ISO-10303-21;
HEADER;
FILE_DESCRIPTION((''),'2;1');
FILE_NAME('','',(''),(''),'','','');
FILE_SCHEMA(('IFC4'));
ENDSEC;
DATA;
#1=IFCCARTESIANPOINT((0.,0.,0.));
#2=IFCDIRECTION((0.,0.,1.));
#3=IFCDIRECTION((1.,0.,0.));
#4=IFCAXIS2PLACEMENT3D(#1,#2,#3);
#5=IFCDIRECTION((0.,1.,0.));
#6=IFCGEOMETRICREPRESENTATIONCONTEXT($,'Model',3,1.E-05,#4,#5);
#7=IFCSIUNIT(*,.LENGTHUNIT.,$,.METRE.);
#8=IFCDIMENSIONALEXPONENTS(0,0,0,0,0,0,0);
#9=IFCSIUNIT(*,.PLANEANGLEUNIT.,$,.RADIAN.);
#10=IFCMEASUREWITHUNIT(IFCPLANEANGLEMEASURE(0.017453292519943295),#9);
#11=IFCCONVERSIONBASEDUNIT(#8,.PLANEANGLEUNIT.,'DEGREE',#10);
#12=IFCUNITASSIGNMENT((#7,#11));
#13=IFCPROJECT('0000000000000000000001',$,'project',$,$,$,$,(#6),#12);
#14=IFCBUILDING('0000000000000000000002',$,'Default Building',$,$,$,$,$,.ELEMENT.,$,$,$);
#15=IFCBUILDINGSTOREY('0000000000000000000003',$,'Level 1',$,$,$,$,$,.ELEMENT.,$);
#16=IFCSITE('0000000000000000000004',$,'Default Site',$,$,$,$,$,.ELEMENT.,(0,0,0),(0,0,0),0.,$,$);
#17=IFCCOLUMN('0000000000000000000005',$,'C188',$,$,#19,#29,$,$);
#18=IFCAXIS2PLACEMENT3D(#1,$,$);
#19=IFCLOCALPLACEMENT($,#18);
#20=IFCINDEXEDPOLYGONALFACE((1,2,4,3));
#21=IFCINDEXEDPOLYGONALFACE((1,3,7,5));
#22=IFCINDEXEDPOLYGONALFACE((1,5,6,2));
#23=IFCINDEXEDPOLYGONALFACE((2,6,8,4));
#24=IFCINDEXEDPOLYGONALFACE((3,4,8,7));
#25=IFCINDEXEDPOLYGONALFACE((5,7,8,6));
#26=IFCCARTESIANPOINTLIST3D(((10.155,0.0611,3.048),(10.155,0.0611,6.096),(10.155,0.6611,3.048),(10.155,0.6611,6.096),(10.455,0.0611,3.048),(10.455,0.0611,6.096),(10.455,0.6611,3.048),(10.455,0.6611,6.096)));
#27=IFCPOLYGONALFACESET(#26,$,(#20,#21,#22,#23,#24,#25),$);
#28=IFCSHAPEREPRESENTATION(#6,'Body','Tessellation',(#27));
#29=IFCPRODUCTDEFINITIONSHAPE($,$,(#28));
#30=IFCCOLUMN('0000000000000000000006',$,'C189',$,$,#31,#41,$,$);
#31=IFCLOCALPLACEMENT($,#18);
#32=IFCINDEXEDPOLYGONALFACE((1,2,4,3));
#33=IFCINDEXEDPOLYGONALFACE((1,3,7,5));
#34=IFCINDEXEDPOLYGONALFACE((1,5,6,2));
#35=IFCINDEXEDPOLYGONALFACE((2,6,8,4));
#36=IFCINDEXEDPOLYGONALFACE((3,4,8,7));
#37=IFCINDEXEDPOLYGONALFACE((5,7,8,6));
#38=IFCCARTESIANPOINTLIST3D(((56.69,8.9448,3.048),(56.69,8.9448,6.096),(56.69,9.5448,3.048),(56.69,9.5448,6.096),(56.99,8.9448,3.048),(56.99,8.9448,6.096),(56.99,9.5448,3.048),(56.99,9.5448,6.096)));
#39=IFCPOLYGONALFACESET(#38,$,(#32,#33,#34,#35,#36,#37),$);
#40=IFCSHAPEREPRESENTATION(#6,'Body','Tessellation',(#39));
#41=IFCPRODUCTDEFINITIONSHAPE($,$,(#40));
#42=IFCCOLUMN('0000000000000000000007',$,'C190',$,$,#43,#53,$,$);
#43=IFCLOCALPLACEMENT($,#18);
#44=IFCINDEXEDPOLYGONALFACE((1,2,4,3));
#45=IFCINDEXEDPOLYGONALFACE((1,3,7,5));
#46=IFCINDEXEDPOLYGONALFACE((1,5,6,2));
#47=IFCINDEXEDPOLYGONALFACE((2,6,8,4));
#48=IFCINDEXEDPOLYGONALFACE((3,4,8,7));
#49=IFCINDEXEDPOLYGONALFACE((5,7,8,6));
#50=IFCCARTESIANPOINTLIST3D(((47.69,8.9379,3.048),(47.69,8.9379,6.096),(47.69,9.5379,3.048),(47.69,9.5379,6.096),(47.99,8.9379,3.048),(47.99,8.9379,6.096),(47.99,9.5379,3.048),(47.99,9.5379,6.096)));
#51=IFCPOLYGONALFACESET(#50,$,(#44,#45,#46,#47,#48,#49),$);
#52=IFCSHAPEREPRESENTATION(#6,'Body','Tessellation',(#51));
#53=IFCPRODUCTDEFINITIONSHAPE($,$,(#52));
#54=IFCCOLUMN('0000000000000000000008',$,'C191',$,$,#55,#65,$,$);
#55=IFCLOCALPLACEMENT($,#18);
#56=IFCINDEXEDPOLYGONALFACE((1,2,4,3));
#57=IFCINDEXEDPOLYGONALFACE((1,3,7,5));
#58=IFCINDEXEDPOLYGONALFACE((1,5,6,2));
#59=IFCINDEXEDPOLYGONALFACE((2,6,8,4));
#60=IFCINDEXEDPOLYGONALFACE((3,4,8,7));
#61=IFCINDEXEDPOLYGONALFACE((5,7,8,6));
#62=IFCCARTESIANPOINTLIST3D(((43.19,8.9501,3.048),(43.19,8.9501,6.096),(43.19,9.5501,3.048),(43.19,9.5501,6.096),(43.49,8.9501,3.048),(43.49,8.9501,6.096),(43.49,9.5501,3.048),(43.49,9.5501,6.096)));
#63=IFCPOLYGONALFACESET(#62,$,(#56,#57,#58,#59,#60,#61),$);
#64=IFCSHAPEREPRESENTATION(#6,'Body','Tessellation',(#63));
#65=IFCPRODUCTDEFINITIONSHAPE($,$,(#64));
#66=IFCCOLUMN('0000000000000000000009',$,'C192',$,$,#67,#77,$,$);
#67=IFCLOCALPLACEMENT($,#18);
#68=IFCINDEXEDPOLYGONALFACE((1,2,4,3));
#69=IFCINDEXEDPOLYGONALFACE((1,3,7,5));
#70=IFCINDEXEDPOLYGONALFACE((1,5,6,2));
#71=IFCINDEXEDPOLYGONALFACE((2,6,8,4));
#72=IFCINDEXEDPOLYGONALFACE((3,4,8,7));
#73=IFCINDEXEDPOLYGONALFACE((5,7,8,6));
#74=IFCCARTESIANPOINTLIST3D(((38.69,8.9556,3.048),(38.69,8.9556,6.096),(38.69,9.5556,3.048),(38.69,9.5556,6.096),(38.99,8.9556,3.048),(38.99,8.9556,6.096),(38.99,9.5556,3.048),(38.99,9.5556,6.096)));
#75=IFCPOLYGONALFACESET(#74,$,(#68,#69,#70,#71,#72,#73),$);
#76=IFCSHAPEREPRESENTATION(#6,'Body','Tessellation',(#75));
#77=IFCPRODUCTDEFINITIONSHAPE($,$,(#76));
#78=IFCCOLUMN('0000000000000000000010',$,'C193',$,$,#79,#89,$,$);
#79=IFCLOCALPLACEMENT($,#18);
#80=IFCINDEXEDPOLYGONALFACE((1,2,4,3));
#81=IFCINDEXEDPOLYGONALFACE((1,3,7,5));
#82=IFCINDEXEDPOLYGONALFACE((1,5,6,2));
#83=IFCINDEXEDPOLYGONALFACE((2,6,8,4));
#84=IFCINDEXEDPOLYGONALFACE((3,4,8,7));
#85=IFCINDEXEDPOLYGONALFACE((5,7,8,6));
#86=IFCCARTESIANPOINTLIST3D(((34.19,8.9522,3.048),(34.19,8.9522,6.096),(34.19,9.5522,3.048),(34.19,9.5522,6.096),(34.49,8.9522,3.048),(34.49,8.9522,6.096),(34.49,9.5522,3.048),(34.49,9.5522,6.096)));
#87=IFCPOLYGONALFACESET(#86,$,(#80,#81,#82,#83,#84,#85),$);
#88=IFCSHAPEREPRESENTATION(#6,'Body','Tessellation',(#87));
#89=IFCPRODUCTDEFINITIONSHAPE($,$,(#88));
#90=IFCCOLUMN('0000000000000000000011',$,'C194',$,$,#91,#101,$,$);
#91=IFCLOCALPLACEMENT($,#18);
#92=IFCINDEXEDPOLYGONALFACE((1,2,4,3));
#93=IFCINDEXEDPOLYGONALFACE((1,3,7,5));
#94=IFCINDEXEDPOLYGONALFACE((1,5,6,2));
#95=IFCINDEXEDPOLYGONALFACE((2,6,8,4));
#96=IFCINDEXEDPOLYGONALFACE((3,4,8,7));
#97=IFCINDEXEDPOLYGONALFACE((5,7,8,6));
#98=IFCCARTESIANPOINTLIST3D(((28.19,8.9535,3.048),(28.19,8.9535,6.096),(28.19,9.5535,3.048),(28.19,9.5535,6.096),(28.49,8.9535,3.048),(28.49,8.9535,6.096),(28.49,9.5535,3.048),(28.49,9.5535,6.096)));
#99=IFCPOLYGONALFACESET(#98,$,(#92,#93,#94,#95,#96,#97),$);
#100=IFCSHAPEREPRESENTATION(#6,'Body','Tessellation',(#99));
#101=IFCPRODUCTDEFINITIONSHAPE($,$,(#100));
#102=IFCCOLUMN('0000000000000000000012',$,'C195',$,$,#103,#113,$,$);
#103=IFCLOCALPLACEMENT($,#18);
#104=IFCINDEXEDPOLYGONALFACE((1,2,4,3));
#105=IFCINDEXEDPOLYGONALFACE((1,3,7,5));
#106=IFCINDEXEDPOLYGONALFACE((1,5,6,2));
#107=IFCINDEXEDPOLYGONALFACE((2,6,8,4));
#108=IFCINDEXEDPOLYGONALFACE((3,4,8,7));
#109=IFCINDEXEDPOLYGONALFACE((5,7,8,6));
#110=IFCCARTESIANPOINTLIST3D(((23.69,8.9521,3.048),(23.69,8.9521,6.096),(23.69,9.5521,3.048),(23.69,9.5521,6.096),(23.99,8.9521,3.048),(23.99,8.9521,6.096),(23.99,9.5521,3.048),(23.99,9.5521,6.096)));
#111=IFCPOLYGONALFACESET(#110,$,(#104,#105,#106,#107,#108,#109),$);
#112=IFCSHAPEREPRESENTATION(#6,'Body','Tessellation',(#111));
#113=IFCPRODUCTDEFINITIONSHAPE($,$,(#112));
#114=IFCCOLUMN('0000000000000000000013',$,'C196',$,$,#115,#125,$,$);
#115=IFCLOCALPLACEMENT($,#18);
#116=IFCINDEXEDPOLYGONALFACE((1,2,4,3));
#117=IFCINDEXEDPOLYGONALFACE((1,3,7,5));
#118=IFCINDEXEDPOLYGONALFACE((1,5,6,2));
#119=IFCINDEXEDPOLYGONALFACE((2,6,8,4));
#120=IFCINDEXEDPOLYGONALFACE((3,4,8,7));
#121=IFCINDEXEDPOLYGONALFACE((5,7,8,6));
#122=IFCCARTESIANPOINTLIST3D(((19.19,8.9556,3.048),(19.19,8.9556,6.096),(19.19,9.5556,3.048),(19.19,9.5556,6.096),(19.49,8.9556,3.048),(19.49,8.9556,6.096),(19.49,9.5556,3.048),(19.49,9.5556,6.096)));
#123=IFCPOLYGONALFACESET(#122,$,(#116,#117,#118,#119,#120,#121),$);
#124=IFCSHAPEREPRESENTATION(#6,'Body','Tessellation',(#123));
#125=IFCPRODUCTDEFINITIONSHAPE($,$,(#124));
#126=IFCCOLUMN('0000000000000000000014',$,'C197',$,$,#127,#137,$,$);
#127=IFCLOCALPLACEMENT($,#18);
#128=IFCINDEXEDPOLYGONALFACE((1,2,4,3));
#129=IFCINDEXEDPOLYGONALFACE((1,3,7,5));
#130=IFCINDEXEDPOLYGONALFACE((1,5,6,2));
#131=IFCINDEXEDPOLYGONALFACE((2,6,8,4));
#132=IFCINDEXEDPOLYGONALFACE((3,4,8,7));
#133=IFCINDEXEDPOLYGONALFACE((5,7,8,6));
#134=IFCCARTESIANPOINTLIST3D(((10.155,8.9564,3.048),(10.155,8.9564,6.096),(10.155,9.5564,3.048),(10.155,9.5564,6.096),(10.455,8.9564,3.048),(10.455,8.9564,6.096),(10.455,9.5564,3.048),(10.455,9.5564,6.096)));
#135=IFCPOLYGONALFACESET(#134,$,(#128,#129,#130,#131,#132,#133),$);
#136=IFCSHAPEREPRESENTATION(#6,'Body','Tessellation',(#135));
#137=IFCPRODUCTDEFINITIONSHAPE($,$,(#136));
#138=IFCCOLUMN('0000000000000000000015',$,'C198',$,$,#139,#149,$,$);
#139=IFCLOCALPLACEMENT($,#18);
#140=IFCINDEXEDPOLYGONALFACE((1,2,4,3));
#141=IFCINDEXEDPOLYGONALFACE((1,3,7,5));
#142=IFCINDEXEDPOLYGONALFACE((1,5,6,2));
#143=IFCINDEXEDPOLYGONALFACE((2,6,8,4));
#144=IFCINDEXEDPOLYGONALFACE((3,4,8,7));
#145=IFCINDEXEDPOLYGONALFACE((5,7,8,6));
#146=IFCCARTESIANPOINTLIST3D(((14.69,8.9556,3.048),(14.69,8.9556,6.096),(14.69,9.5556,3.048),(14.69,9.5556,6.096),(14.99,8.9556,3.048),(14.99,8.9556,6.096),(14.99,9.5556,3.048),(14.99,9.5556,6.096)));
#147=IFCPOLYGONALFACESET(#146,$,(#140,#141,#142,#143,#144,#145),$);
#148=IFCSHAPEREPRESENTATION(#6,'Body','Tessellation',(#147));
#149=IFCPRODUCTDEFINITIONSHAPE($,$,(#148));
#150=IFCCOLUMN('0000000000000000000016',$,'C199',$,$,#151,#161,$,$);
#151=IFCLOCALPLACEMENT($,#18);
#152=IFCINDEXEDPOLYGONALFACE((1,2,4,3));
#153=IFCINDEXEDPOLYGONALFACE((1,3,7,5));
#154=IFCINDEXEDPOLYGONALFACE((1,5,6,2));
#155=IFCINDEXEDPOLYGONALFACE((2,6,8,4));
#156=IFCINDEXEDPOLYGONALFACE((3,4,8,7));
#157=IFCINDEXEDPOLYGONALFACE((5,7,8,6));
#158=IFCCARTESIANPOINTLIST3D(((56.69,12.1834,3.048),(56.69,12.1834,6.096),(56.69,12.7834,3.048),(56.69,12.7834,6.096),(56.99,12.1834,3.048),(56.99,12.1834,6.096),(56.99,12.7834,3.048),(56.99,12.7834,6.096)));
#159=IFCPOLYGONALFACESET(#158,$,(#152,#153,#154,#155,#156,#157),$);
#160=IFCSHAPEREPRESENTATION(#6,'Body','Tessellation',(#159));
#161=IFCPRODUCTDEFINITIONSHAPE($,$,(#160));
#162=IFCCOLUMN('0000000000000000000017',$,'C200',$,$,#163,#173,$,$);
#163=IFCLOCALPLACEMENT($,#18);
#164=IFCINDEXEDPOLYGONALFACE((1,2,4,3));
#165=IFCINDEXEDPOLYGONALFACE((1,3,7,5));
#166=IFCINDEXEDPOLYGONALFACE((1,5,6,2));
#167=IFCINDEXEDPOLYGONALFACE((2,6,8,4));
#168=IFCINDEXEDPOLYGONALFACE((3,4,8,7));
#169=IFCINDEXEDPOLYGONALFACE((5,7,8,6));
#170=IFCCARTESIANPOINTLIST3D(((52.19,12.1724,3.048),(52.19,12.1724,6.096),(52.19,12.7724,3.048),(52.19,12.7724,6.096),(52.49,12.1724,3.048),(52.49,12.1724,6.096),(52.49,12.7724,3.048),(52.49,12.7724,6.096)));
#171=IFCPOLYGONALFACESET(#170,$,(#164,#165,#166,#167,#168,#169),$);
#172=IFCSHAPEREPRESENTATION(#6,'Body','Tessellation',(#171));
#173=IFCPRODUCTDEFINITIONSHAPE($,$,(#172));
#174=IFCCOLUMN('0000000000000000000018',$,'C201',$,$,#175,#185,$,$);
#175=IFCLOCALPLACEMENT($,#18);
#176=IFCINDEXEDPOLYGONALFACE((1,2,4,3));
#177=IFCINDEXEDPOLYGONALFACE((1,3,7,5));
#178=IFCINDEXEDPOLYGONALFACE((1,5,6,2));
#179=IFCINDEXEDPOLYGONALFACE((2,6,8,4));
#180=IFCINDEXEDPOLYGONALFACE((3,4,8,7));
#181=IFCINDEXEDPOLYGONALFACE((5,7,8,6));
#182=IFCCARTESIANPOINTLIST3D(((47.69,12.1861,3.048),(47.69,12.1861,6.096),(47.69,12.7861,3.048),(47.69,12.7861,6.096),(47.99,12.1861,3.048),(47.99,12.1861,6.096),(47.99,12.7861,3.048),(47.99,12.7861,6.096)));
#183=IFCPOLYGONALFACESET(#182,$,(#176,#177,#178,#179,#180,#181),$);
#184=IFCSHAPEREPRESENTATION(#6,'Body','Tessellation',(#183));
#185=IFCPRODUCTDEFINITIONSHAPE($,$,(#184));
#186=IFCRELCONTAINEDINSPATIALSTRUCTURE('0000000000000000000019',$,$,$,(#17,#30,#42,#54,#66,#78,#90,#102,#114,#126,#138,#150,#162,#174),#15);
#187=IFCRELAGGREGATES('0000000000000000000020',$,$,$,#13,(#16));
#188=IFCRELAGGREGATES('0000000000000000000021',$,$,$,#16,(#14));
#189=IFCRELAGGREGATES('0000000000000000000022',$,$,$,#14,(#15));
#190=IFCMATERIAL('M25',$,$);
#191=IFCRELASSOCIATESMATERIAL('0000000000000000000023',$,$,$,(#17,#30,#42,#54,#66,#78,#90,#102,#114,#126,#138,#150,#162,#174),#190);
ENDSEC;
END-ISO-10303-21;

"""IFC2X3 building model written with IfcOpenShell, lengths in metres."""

from ifc_helpers import new_model, entity, si_unit, converted_unit, direction, frame, frame_2d, origin_with_axes, place, context, project, spatial, rectangle, extrude, material, element, save


model = new_model("IFC2X3")

# Units and contexts
model_context = context("Model", 3, precision=1e-05, world=origin_with_axes(), true_north=direction((0.0, 1.0, 0.0)))
ifc_project = project(units=[si_unit("LENGTHUNIT", "METRE"), converted_unit("PLANEANGLEUNIT", "DEGREE", entity("IfcPlaneAngleMeasure", 0.017453292519943295), si_unit("PLANEANGLEUNIT", "RADIAN"), dimensions=[0, 0, 0, 0, 0, 0, 0])], contexts=[model_context])

# Site, building, storey
site = spatial("IfcSite", under=ifc_project, Name="Default Site", CompositionType="ELEMENT", RefLatitude=(0, 0, 0), RefLongitude=(0, 0, 0), RefElevation=0.0)
building = spatial("IfcBuilding", under=site, Name="Default Building", CompositionType="ELEMENT")
storey = spatial("IfcBuildingStorey", under=building, Name="Level 1", CompositionType="ELEMENT")

# Columns
ifc_material = material(Name="M25")
placement = place(None, origin_with_axes())
element("IfcColumn", 1, at=placement, inside=storey, material=ifc_material, Name="C188", context=model_context, shape_type="SweptSolid", body=[
    extrude(rectangle(XDim=0.3, YDim=0.6, at=frame_2d((0.0, 0.0), x_axis=(1.0, 0.0, 0.0))), frame((10.305, 0.3611, 3.048), z_axis=(0.0, 0.0, 1.0), x_axis=(1.0, 0.0, 0.0)), (0.0, 0.0, 1.0), 3.048),
])
element("IfcColumn", 2, at=placement, inside=storey, material=ifc_material, Name="C189", context=model_context, shape_type="SweptSolid", body=[
    extrude(rectangle(XDim=0.3, YDim=0.6, at=frame_2d((0.0, 0.0), x_axis=(1.0, 0.0, 0.0))), frame((56.84, 9.2448, 3.048), z_axis=(0.0, 0.0, 1.0), x_axis=(1.0, 0.0, 0.0)), (0.0, 0.0, 1.0), 3.048),
])
element("IfcColumn", 3, at=placement, inside=storey, material=ifc_material, Name="C190", context=model_context, shape_type="SweptSolid", body=[
    extrude(rectangle(XDim=0.3, YDim=0.6, at=frame_2d((0.0, 0.0), x_axis=(1.0, 0.0, 0.0))), frame((47.84, 9.2379, 3.048), z_axis=(0.0, 0.0, 1.0), x_axis=(1.0, 0.0, 0.0)), (0.0, 0.0, 1.0), 3.048),
])
element("IfcColumn", 4, at=placement, inside=storey, material=ifc_material, Name="C191", context=model_context, shape_type="SweptSolid", body=[
    extrude(rectangle(XDim=0.3, YDim=0.6, at=frame_2d((0.0, 0.0), x_axis=(1.0, 0.0, 0.0))), frame((43.34, 9.2501, 3.048), z_axis=(0.0, 0.0, 1.0), x_axis=(1.0, 0.0, 0.0)), (0.0, 0.0, 1.0), 3.048),
])
element("IfcColumn", 5, at=placement, inside=storey, material=ifc_material, Name="C192", context=model_context, shape_type="SweptSolid", body=[
    extrude(rectangle(XDim=0.3, YDim=0.6, at=frame_2d((0.0, 0.0), x_axis=(1.0, 0.0, 0.0))), frame((38.84, 9.2556, 3.048), z_axis=(0.0, 0.0, 1.0), x_axis=(1.0, 0.0, 0.0)), (0.0, 0.0, 1.0), 3.048),
])
element("IfcColumn", 6, at=placement, inside=storey, material=ifc_material, Name="C193", context=model_context, shape_type="SweptSolid", body=[
    extrude(rectangle(XDim=0.3, YDim=0.6, at=frame_2d((0.0, 0.0), x_axis=(1.0, 0.0, 0.0))), frame((34.34, 9.2522, 3.048), z_axis=(0.0, 0.0, 1.0), x_axis=(1.0, 0.0, 0.0)), (0.0, 0.0, 1.0), 3.048),
])
element("IfcColumn", 7, at=placement, inside=storey, material=ifc_material, Name="C194", context=model_context, shape_type="SweptSolid", body=[
    extrude(rectangle(XDim=0.3, YDim=0.6, at=frame_2d((0.0, 0.0), x_axis=(1.0, 0.0, 0.0))), frame((28.34, 9.2535, 3.048), z_axis=(0.0, 0.0, 1.0), x_axis=(1.0, 0.0, 0.0)), (0.0, 0.0, 1.0), 3.048),
])
element("IfcColumn", 8, at=placement, inside=storey, material=ifc_material, Name="C195", context=model_context, shape_type="SweptSolid", body=[
    extrude(rectangle(XDim=0.3, YDim=0.6, at=frame_2d((0.0, 0.0), x_axis=(1.0, 0.0, 0.0))), frame((23.84, 9.2521, 3.048), z_axis=(0.0, 0.0, 1.0), x_axis=(1.0, 0.0, 0.0)), (0.0, 0.0, 1.0), 3.048),
])
element("IfcColumn", 9, at=placement, inside=storey, material=ifc_material, Name="C196", context=model_context, shape_type="SweptSolid", body=[
    extrude(rectangle(XDim=0.3, YDim=0.6, at=frame_2d((0.0, 0.0), x_axis=(1.0, 0.0, 0.0))), frame((19.34, 9.2556, 3.048), z_axis=(0.0, 0.0, 1.0), x_axis=(1.0, 0.0, 0.0)), (0.0, 0.0, 1.0), 3.048),
])
element("IfcColumn", 10, at=placement, inside=storey, material=ifc_material, Name="C197", context=model_context, shape_type="SweptSolid", body=[
    extrude(rectangle(XDim=0.3, YDim=0.6, at=frame_2d((0.0, 0.0), x_axis=(1.0, 0.0, 0.0))), frame((10.305, 9.2564, 3.048), z_axis=(0.0, 0.0, 1.0), x_axis=(1.0, 0.0, 0.0)), (0.0, 0.0, 1.0), 3.048),
])
element("IfcColumn", 11, at=placement, inside=storey, material=ifc_material, Name="C198", context=model_context, shape_type="SweptSolid", body=[
    extrude(rectangle(XDim=0.3, YDim=0.6, at=frame_2d((0.0, 0.0), x_axis=(1.0, 0.0, 0.0))), frame((14.84, 9.2556, 3.048), z_axis=(0.0, 0.0, 1.0), x_axis=(1.0, 0.0, 0.0)), (0.0, 0.0, 1.0), 3.048),
])
element("IfcColumn", 12, at=placement, inside=storey, material=ifc_material, Name="C199", context=model_context, shape_type="SweptSolid", body=[
    extrude(rectangle(XDim=0.3, YDim=0.6, at=frame_2d((0.0, 0.0), x_axis=(1.0, 0.0, 0.0))), frame((56.84, 12.4834, 3.048), z_axis=(0.0, 0.0, 1.0), x_axis=(1.0, 0.0, 0.0)), (0.0, 0.0, 1.0), 3.048),
])
element("IfcColumn", 13, at=placement, inside=storey, material=ifc_material, Name="C200", context=model_context, shape_type="SweptSolid", body=[
    extrude(rectangle(XDim=0.3, YDim=0.6, at=frame_2d((0.0, 0.0), x_axis=(1.0, 0.0, 0.0))), frame((52.34, 12.4724, 3.048), z_axis=(0.0, 0.0, 1.0), x_axis=(1.0, 0.0, 0.0)), (0.0, 0.0, 1.0), 3.048),
])
element("IfcColumn", 14, at=placement, inside=storey, material=ifc_material, Name="C201", context=model_context, shape_type="SweptSolid", body=[
    extrude(rectangle(XDim=0.3, YDim=0.6, at=frame_2d((0.0, 0.0), x_axis=(1.0, 0.0, 0.0))), frame((47.84, 12.4861, 3.048), z_axis=(0.0, 0.0, 1.0), x_axis=(1.0, 0.0, 0.0)), (0.0, 0.0, 1.0), 3.048),
])

save(model, "model.ifc")
